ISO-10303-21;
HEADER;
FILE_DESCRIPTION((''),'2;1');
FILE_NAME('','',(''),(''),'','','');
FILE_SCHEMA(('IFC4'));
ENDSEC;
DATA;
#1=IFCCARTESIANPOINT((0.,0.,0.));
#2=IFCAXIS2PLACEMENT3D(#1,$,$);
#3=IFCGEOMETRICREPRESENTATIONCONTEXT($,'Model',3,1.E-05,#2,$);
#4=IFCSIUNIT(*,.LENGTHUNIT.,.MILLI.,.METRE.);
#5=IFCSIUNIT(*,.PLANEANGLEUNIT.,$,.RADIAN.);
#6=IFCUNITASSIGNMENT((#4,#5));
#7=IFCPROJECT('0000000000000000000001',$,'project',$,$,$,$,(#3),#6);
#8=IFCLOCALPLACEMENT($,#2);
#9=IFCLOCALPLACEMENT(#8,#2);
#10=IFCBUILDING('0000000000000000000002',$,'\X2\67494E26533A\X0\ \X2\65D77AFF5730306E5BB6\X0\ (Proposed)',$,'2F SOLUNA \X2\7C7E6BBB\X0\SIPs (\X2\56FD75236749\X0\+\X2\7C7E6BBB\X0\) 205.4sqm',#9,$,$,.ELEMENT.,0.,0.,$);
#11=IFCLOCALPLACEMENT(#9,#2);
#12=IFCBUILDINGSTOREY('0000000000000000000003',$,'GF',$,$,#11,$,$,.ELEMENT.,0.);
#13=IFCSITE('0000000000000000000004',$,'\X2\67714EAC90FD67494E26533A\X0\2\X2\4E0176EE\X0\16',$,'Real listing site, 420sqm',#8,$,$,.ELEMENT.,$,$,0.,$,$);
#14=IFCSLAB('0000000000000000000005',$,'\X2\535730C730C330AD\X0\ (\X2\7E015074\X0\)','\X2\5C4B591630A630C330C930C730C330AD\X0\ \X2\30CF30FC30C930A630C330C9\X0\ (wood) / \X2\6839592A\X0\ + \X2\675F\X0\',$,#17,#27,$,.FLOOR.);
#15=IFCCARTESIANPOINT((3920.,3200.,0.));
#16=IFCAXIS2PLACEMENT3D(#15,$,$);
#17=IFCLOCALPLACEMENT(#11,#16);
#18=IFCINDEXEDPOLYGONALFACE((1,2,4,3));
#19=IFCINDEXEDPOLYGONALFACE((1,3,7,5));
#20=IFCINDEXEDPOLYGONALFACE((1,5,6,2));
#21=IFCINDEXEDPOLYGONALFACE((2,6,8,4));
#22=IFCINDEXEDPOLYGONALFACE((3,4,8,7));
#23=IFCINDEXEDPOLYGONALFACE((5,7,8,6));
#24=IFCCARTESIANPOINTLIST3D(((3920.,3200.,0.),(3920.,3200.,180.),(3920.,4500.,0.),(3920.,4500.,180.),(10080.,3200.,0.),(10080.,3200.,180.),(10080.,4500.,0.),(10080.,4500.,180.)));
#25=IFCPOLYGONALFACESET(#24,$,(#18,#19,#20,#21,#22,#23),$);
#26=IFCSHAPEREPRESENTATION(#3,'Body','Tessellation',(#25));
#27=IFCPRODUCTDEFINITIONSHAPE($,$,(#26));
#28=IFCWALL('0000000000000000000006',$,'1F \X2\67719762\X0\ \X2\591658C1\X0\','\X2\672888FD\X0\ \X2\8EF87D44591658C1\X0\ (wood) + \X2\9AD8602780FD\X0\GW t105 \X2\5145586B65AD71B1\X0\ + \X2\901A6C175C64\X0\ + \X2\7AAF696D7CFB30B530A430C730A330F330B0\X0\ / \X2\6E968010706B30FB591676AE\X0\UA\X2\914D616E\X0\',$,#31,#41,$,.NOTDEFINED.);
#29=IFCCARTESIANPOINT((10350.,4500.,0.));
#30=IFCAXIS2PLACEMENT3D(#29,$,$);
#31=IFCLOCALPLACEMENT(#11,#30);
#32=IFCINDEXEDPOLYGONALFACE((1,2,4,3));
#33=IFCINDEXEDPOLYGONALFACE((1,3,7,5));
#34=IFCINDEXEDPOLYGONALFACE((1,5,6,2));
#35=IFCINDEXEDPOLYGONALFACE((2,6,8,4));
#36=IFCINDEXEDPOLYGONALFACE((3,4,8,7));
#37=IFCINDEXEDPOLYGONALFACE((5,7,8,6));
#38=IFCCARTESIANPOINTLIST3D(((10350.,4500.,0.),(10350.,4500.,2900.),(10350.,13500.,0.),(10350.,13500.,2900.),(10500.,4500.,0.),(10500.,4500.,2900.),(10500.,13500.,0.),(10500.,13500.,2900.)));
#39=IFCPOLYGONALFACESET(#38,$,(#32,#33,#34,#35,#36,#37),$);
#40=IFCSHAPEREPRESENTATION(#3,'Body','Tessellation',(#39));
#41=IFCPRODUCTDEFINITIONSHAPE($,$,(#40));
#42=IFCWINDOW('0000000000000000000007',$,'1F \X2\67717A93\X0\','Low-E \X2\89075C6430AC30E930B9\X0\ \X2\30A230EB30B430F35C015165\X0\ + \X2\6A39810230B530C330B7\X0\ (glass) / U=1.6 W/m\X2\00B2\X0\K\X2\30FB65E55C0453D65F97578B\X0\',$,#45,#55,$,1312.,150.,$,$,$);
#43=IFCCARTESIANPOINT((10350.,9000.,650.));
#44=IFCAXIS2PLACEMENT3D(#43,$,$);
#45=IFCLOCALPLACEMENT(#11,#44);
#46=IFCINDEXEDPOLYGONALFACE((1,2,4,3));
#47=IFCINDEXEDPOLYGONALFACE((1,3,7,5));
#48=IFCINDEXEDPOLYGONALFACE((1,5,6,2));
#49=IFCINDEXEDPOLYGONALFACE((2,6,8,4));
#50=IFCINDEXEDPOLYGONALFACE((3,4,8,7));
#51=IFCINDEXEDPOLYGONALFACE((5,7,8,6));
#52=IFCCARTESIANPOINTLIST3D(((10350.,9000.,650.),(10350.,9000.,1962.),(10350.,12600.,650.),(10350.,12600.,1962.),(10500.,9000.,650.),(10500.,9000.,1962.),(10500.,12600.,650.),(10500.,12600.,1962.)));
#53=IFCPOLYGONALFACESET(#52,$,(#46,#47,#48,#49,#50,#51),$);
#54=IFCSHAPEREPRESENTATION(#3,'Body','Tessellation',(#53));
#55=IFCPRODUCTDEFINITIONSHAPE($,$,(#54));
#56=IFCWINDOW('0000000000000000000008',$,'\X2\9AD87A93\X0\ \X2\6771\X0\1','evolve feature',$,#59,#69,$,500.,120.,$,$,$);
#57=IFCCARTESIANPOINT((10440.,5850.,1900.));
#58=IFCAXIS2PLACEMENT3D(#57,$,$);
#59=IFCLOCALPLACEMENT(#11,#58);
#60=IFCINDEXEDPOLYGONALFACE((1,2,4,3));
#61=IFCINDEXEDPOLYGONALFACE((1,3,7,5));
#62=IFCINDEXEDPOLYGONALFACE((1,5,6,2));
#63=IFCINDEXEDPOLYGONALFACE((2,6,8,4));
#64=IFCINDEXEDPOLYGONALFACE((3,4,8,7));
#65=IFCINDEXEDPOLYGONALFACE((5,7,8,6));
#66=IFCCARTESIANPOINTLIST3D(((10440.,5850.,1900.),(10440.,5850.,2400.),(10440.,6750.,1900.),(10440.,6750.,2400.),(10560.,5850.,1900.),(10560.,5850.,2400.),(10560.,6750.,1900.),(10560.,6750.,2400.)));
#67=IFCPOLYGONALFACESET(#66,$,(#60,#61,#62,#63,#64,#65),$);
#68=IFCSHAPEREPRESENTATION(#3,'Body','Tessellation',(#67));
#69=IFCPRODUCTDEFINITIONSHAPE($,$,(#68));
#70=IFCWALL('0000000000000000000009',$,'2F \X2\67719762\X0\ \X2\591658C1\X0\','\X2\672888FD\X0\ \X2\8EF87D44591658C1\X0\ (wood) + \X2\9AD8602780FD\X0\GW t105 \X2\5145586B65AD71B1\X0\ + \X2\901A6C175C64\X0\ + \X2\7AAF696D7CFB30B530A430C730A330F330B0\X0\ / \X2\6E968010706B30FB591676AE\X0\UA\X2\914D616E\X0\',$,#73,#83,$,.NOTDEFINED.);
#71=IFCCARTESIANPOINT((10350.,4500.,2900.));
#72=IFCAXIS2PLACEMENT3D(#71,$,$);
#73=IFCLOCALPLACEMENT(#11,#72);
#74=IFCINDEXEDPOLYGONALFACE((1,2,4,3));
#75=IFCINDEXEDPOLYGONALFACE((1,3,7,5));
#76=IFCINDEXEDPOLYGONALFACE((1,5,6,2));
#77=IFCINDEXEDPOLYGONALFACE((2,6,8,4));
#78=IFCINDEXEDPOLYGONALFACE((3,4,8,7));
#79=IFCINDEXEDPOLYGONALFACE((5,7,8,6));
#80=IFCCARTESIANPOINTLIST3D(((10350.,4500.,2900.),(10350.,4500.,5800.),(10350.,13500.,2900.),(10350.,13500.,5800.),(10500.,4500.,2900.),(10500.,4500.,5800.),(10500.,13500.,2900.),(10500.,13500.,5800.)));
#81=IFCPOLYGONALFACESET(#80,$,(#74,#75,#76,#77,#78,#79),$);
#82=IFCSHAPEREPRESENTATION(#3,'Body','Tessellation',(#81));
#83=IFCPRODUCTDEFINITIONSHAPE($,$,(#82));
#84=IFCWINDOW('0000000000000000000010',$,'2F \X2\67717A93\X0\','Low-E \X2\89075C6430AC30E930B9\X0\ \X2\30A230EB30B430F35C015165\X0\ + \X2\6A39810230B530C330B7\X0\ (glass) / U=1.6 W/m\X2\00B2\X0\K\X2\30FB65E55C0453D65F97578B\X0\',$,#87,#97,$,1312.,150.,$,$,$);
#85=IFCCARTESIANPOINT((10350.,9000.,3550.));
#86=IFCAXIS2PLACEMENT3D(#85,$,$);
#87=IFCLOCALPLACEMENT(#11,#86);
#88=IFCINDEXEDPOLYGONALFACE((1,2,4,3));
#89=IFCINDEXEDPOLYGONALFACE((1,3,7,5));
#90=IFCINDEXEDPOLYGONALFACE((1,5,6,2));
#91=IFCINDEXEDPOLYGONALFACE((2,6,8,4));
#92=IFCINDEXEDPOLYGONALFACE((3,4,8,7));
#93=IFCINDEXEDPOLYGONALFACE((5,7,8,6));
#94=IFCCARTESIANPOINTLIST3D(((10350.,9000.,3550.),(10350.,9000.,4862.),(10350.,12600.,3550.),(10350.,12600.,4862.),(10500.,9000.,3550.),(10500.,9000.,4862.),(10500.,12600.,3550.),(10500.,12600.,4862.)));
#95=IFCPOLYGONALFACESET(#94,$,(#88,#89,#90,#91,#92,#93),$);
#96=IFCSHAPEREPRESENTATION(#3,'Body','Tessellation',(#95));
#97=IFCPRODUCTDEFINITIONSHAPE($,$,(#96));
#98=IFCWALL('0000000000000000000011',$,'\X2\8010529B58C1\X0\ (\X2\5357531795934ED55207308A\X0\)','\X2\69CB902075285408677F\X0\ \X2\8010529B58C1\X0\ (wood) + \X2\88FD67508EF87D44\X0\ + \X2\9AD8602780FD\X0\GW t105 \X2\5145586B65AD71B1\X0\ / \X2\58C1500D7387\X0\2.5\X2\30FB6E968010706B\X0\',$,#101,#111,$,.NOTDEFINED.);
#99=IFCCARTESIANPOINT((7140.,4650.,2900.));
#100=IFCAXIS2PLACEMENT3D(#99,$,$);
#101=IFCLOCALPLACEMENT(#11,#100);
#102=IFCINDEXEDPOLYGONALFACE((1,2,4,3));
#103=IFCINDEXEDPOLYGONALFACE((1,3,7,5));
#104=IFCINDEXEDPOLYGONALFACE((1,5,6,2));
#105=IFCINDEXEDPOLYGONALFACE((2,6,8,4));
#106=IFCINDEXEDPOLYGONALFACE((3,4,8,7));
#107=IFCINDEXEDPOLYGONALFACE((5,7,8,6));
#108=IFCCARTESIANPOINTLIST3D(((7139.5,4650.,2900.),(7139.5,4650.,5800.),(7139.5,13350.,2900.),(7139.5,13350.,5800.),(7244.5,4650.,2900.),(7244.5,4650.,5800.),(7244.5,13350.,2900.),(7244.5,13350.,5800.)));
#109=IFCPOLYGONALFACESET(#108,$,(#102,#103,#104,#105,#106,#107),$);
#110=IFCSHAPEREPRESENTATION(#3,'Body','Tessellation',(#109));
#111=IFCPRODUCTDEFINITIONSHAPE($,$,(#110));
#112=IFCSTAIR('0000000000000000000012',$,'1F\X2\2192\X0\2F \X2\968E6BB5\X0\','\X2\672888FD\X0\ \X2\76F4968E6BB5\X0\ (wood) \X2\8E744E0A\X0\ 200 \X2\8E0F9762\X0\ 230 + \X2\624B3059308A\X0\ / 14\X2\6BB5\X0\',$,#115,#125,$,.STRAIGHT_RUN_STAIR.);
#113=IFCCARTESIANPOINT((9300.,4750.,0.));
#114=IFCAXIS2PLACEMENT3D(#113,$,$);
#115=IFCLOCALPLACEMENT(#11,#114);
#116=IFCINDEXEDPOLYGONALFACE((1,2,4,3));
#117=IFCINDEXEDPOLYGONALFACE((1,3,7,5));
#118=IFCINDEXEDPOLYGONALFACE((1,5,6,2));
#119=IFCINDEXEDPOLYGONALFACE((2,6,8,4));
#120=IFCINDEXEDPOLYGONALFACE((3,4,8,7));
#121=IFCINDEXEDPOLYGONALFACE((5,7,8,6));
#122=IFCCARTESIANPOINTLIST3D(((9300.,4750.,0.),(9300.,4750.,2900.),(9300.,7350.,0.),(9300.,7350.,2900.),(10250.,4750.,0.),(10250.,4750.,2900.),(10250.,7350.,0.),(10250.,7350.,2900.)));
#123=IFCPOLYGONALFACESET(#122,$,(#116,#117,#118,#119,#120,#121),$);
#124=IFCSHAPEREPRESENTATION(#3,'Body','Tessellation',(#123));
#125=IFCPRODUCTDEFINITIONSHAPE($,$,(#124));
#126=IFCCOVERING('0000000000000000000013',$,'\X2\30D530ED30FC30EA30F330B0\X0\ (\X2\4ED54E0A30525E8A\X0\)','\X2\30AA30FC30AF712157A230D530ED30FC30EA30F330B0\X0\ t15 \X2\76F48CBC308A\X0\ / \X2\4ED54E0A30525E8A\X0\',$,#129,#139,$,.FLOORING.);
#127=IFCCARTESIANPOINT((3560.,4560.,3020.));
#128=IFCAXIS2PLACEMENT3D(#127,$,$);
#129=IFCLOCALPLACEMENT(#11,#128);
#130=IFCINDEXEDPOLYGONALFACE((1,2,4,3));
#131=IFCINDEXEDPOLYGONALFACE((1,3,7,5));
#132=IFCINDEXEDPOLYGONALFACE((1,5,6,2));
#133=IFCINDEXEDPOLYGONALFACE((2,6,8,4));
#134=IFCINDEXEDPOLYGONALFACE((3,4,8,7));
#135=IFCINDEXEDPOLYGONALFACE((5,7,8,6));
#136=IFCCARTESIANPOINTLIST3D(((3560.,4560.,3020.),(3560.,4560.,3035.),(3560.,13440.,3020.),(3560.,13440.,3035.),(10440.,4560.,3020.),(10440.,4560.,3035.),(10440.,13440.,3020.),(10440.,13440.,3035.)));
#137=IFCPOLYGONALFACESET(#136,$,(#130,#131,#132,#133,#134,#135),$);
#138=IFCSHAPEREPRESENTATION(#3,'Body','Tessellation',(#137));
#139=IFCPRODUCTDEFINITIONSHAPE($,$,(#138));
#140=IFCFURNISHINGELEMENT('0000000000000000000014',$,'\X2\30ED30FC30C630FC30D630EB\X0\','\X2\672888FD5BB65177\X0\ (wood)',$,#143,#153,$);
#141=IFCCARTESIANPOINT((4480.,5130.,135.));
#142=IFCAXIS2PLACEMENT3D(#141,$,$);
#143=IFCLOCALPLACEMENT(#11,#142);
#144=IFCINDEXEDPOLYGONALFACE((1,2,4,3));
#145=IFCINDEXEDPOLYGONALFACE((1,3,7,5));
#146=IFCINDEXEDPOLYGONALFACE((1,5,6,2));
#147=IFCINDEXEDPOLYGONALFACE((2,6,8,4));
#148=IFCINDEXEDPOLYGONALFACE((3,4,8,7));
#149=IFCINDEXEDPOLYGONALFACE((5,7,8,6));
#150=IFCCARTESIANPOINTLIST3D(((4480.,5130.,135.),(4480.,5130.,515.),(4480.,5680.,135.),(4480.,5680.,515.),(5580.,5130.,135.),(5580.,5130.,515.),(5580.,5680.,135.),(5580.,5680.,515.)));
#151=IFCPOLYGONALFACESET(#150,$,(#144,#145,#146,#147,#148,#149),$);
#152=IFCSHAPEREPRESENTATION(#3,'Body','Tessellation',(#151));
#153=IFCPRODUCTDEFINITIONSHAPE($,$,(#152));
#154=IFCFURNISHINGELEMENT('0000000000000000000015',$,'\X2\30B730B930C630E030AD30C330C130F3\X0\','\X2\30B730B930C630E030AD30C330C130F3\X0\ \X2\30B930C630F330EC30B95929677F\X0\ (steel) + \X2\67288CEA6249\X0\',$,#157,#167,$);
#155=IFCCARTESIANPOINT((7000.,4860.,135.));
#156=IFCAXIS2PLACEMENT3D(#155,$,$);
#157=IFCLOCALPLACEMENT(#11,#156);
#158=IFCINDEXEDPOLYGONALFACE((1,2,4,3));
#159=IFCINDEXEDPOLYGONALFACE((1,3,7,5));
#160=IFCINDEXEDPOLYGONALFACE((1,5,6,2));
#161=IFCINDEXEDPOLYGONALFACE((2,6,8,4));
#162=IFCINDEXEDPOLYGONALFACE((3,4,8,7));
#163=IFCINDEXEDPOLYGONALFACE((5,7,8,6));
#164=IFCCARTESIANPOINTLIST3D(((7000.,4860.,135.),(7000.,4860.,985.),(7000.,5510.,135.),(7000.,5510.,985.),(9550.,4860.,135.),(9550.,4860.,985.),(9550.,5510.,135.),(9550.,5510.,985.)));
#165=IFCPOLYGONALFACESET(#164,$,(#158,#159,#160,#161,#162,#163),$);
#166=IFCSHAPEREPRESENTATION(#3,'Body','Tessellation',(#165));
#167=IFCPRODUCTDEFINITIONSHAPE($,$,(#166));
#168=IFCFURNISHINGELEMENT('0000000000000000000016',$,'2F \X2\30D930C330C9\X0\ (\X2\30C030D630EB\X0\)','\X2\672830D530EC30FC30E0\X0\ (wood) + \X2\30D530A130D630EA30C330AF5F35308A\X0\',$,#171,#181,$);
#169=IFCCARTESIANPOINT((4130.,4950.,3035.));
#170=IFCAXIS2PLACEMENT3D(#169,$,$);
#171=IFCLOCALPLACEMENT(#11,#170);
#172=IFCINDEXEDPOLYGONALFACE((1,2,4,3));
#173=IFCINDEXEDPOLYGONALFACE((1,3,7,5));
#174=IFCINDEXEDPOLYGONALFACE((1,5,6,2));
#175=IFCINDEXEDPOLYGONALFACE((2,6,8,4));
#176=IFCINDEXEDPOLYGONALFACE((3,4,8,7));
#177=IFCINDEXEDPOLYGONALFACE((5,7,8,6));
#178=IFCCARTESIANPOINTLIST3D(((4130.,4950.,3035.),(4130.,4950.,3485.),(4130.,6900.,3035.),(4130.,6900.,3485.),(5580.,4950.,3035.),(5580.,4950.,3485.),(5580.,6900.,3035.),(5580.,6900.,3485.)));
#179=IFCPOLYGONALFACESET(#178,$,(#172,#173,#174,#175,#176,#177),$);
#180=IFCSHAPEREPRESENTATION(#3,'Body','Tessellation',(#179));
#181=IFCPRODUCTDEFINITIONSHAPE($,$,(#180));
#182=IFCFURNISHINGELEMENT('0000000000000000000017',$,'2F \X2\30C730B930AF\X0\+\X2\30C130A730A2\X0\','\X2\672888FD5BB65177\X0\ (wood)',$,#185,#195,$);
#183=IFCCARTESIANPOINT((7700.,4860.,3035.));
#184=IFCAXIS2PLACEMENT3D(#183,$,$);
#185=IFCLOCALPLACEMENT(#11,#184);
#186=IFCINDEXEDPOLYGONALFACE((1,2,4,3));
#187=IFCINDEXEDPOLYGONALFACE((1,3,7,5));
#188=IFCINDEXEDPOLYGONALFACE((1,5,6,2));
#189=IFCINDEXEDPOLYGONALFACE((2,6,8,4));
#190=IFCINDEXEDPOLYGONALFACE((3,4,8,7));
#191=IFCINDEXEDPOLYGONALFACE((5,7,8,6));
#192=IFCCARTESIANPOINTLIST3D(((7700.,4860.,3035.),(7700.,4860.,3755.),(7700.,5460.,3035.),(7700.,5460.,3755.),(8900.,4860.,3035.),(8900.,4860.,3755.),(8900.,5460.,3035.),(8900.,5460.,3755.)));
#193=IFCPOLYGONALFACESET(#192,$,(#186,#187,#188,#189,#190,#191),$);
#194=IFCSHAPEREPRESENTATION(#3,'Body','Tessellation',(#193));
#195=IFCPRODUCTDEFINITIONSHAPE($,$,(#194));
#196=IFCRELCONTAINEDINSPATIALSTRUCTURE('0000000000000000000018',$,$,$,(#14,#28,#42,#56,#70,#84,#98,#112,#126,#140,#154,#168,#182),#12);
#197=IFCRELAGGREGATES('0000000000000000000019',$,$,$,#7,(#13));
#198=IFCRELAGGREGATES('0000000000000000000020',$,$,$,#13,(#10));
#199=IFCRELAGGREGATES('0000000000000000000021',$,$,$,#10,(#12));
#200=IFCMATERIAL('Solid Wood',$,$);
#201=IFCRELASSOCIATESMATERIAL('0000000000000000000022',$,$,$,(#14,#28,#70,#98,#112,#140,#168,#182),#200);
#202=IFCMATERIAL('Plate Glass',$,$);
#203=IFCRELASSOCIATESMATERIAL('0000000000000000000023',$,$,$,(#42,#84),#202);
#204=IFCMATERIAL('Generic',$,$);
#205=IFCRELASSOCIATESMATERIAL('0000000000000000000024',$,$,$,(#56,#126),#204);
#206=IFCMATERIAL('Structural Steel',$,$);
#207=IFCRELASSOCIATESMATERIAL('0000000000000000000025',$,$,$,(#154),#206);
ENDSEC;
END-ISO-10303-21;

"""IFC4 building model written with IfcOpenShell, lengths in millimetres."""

from ifc_helpers import new_model, si_unit, frame, frame_2d, origin, place, context, project, spatial, rectangle, extrude, material, element, fill, save


model = new_model("IFC4")

# Units and contexts
model_context = context("Model", 3, precision=1e-05, world=origin())
ifc_project = project(units=[si_unit("LENGTHUNIT", "METRE", prefix="MILLI"), si_unit("PLANEANGLEUNIT", "RADIAN")], contexts=[model_context])

# Site, building, storey
site_placement = place(None, origin())
site = spatial("IfcSite", under=ifc_project, at=site_placement, Name="東京都杉並区2丁目16", ObjectType="Real listing site, 420sqm", CompositionType="ELEMENT", RefElevation=0.0)
building_placement = place(site_placement, origin())
building = spatial("IfcBuilding", under=site, at=building_placement, Name="杉並区 旗竿地の家 (Proposed)", ObjectType="2F SOLUNA 籾殻SIPs (国産杉+籾殻) 205.4sqm", CompositionType="ELEMENT", ElevationOfRefHeight=0.0, ElevationOfTerrain=0.0)
storey_placement = place(building_placement, origin())
storey = spatial("IfcBuildingStorey", under=building, at=storey_placement, Name="GF", CompositionType="ELEMENT", Elevation=0.0)

# Slab
ifc_material_1 = material(Name="Solid Wood")
slab_placement = place(storey_placement, frame((3920.0, 3200.0, 0.0)))
element("IfcSlab", 1, at=slab_placement, inside=storey, material=ifc_material_1, Name="南デッキ (縁側)", Description="屋外ウッドデッキ ハードウッド (wood) / 根太 + 束", PredefinedType="FLOOR", context=model_context, shape_type="SweptSolid", body=[
    extrude(rectangle(XDim=6160.0, YDim=1300.0, at=frame_2d((3080.0, 650.0))), frame((3920.0, 3200.0, 0.0)), (0.0, 0.0, 1.0), 180.0),
])

# Wall, openings, windows
wall_1_placement = place(storey_placement, frame((10350.0, 4500.0, 0.0)))
wall_1 = element("IfcWall", 2, at=wall_1_placement, inside=storey, material=ifc_material_1, Name="1F 東面 外壁", Description="木製 軸組外壁 (wood) + 高性能GW t105 充填断熱 + 通気層 + 窯業系サイディング / 準耐火・外皮UA配慮", PredefinedType="NOTDEFINED", context=model_context, shape_type="SweptSolid", body=[
    extrude(rectangle(XDim=150.0, YDim=9000.0, at=frame_2d((75.0, 4500.0))), frame((10350.0, 4500.0, 0.0)), (0.0, 0.0, 1.0), 2900.0),
])
opening_1_placement = place(storey_placement, frame((10350.0, 9000.0, 650.0)))
opening_1 = element("IfcOpeningElement", 3, at=opening_1_placement, cuts=wall_1, PredefinedType="NOTDEFINED", context=model_context, shape_type="SweptSolid", body=[
    extrude(rectangle(XDim=150.0, YDim=3600.0, at=frame_2d((75.0, 1800.0))), frame((10350.0, 9000.0, 650.0)), (0.0, 0.0, 1.0), 1312.0),
])
opening_2_placement = place(storey_placement, frame((10440.0, 5850.0, 1900.0)))
opening_2 = element("IfcOpeningElement", 4, at=opening_2_placement, cuts=wall_1, PredefinedType="NOTDEFINED", context=model_context, shape_type="SweptSolid", body=[
    extrude(rectangle(XDim=120.0, YDim=900.0, at=frame_2d((60.0, 450.0))), frame((10440.0, 5850.0, 1900.0)), (0.0, 0.0, 1.0), 500.0),
])
ifc_material_2 = material(Name="Plate Glass")
window_1_placement = place(storey_placement, frame((10350.0, 9000.0, 650.0)))
window_1 = element("IfcWindow", 5, at=window_1_placement, inside=storey, material=ifc_material_2, Name="1F 東窓", Description="Low-E 複層ガラス アルゴン封入 + 樹脂サッシ (glass) / U=1.6 W/m²K・日射取得型", OverallHeight=1312.0, OverallWidth=150.0, context=model_context, shape_type="SweptSolid", body=[
    extrude(rectangle(XDim=150.0, YDim=3600.0, at=frame_2d((75.0, 1800.0))), frame((10350.0, 9000.0, 650.0)), (0.0, 0.0, 1.0), 1312.0),
])
fill(opening_1, window_1)
ifc_material_3 = material(Name="Generic")
window_2_placement = place(storey_placement, frame((10440.0, 5850.0, 1900.0)))
window_2 = element("IfcWindow", 6, at=window_2_placement, inside=storey, material=ifc_material_3, Name="高窓 東1", Description="evolve feature", OverallHeight=500.0, OverallWidth=120.0, context=model_context, shape_type="SweptSolid", body=[
    extrude(rectangle(XDim=120.0, YDim=900.0, at=frame_2d((60.0, 450.0))), frame((10440.0, 5850.0, 1900.0)), (0.0, 0.0, 1.0), 500.0),
])
fill(opening_2, window_2)

# Wall, opening, window
wall_2_placement = place(storey_placement, frame((10350.0, 4500.0, 2900.0)))
wall_2 = element("IfcWall", 7, at=wall_2_placement, inside=storey, material=ifc_material_1, Name="2F 東面 外壁", Description="木製 軸組外壁 (wood) + 高性能GW t105 充填断熱 + 通気層 + 窯業系サイディング / 準耐火・外皮UA配慮", PredefinedType="NOTDEFINED", context=model_context, shape_type="SweptSolid", body=[
    extrude(rectangle(XDim=150.0, YDim=9000.0, at=frame_2d((75.0, 4500.0))), frame((10350.0, 4500.0, 2900.0)), (0.0, 0.0, 1.0), 2900.0),
])
opening_3_placement = place(storey_placement, frame((10350.0, 9000.0, 3550.0)))
opening_3 = element("IfcOpeningElement", 8, at=opening_3_placement, cuts=wall_2, PredefinedType="NOTDEFINED", context=model_context, shape_type="SweptSolid", body=[
    extrude(rectangle(XDim=150.0, YDim=3600.0, at=frame_2d((75.0, 1800.0))), frame((10350.0, 9000.0, 3550.0)), (0.0, 0.0, 1.0), 1312.0),
])
window_3_placement = place(storey_placement, frame((10350.0, 9000.0, 3550.0)))
window_3 = element("IfcWindow", 9, at=window_3_placement, inside=storey, material=ifc_material_2, Name="2F 東窓", Description="Low-E 複層ガラス アルゴン封入 + 樹脂サッシ (glass) / U=1.6 W/m²K・日射取得型", OverallHeight=1312.0, OverallWidth=150.0, context=model_context, shape_type="SweptSolid", body=[
    extrude(rectangle(XDim=150.0, YDim=3600.0, at=frame_2d((75.0, 1800.0))), frame((10350.0, 9000.0, 3550.0)), (0.0, 0.0, 1.0), 1312.0),
])
fill(opening_3, window_3)

# Wall
wall_3_placement = place(storey_placement, frame((7140.0, 4650.0, 2900.0)))
element("IfcWall", 10, at=wall_3_placement, inside=storey, material=ifc_material_1, Name="耐力壁 (南北間仕切り)", Description="構造用合板 耐力壁 (wood) + 製材軸組 + 高性能GW t105 充填断熱 / 壁倍率2.5・準耐火", PredefinedType="NOTDEFINED", context=model_context, shape_type="SweptSolid", body=[
    extrude(rectangle(XDim=105.0, YDim=8700.0, at=frame_2d((52.0, 4350.0))), frame((7140.0, 4650.0, 2900.0)), (0.0, 0.0, 1.0), 2900.0),
])

# Stair
stair_placement = place(storey_placement, frame((9300.0, 4750.0, 0.0)))
element("IfcStair", 11, at=stair_placement, inside=storey, material=ifc_material_1, Name="1F→2F 階段", Description="木製 直階段 (wood) 蹴上 200 踏面 230 + 手すり / 14段", PredefinedType="STRAIGHT_RUN_STAIR", context=model_context, shape_type="SweptSolid", body=[
    extrude(rectangle(XDim=950.0, YDim=2600.0, at=frame_2d((475.0, 1300.0))), frame((9300.0, 4750.0, 0.0)), (0.0, 0.0, 1.0), 2900.0),
])

# Covering
covering_placement = place(storey_placement, frame((3560.0, 4560.0, 3020.0)))
element("IfcCovering", 12, at=covering_placement, inside=storey, material=ifc_material_3, Name="フローリング (仕上げ床)", Description="オーク無垢フローリング t15 直貼り / 仕上げ床", PredefinedType="FLOORING", context=model_context, shape_type="SweptSolid", body=[
    extrude(rectangle(XDim=6880.0, YDim=8880.0, at=frame_2d((3440.0, 4440.0))), frame((3560.0, 4560.0, 3020.0)), (0.0, 0.0, 1.0), 15.0),
])

# Furnishing elements
furnishing_1_placement = place(storey_placement, frame((4480.0, 5130.0, 135.0)))
element("IfcFurnishingElement", 13, at=furnishing_1_placement, inside=storey, material=ifc_material_1, Name="ローテーブル", Description="木製家具 (wood)", context=model_context, shape_type="SweptSolid", body=[
    extrude(rectangle(XDim=1100.0, YDim=550.0, at=frame_2d((550.0, 275.0))), frame((4480.0, 5130.0, 135.0)), (0.0, 0.0, 1.0), 380.0),
])
ifc_material_4 = material(Name="Structural Steel")
furnishing_2_placement = place(storey_placement, frame((7000.0, 4860.0, 135.0)))
element("IfcFurnishingElement", 14, at=furnishing_2_placement, inside=storey, material=ifc_material_4, Name="システムキッチン", Description="システムキッチン ステンレス天板 (steel) + 木質扉", context=model_context, shape_type="SweptSolid", body=[
    extrude(rectangle(XDim=2550.0, YDim=650.0, at=frame_2d((1275.0, 325.0))), frame((7000.0, 4860.0, 135.0)), (0.0, 0.0, 1.0), 850.0),
])
furnishing_3_placement = place(storey_placement, frame((4130.0, 4950.0, 3035.0)))
element("IfcFurnishingElement", 15, at=furnishing_3_placement, inside=storey, material=ifc_material_1, Name="2F ベッド (ダブル)", Description="木フレーム (wood) + ファブリック張り", context=model_context, shape_type="SweptSolid", body=[
    extrude(rectangle(XDim=1450.0, YDim=1950.0, at=frame_2d((725.0, 975.0))), frame((4130.0, 4950.0, 3035.0)), (0.0, 0.0, 1.0), 450.0),
])
furnishing_4_placement = place(storey_placement, frame((7700.0, 4860.0, 3035.0)))
element("IfcFurnishingElement", 16, at=furnishing_4_placement, inside=storey, material=ifc_material_1, Name="2F デスク+チェア", Description="木製家具 (wood)", context=model_context, shape_type="SweptSolid", body=[
    extrude(rectangle(XDim=1200.0, YDim=600.0, at=frame_2d((600.0, 300.0))), frame((7700.0, 4860.0, 3035.0)), (0.0, 0.0, 1.0), 720.0),
])

save(model, "model.ifc")
